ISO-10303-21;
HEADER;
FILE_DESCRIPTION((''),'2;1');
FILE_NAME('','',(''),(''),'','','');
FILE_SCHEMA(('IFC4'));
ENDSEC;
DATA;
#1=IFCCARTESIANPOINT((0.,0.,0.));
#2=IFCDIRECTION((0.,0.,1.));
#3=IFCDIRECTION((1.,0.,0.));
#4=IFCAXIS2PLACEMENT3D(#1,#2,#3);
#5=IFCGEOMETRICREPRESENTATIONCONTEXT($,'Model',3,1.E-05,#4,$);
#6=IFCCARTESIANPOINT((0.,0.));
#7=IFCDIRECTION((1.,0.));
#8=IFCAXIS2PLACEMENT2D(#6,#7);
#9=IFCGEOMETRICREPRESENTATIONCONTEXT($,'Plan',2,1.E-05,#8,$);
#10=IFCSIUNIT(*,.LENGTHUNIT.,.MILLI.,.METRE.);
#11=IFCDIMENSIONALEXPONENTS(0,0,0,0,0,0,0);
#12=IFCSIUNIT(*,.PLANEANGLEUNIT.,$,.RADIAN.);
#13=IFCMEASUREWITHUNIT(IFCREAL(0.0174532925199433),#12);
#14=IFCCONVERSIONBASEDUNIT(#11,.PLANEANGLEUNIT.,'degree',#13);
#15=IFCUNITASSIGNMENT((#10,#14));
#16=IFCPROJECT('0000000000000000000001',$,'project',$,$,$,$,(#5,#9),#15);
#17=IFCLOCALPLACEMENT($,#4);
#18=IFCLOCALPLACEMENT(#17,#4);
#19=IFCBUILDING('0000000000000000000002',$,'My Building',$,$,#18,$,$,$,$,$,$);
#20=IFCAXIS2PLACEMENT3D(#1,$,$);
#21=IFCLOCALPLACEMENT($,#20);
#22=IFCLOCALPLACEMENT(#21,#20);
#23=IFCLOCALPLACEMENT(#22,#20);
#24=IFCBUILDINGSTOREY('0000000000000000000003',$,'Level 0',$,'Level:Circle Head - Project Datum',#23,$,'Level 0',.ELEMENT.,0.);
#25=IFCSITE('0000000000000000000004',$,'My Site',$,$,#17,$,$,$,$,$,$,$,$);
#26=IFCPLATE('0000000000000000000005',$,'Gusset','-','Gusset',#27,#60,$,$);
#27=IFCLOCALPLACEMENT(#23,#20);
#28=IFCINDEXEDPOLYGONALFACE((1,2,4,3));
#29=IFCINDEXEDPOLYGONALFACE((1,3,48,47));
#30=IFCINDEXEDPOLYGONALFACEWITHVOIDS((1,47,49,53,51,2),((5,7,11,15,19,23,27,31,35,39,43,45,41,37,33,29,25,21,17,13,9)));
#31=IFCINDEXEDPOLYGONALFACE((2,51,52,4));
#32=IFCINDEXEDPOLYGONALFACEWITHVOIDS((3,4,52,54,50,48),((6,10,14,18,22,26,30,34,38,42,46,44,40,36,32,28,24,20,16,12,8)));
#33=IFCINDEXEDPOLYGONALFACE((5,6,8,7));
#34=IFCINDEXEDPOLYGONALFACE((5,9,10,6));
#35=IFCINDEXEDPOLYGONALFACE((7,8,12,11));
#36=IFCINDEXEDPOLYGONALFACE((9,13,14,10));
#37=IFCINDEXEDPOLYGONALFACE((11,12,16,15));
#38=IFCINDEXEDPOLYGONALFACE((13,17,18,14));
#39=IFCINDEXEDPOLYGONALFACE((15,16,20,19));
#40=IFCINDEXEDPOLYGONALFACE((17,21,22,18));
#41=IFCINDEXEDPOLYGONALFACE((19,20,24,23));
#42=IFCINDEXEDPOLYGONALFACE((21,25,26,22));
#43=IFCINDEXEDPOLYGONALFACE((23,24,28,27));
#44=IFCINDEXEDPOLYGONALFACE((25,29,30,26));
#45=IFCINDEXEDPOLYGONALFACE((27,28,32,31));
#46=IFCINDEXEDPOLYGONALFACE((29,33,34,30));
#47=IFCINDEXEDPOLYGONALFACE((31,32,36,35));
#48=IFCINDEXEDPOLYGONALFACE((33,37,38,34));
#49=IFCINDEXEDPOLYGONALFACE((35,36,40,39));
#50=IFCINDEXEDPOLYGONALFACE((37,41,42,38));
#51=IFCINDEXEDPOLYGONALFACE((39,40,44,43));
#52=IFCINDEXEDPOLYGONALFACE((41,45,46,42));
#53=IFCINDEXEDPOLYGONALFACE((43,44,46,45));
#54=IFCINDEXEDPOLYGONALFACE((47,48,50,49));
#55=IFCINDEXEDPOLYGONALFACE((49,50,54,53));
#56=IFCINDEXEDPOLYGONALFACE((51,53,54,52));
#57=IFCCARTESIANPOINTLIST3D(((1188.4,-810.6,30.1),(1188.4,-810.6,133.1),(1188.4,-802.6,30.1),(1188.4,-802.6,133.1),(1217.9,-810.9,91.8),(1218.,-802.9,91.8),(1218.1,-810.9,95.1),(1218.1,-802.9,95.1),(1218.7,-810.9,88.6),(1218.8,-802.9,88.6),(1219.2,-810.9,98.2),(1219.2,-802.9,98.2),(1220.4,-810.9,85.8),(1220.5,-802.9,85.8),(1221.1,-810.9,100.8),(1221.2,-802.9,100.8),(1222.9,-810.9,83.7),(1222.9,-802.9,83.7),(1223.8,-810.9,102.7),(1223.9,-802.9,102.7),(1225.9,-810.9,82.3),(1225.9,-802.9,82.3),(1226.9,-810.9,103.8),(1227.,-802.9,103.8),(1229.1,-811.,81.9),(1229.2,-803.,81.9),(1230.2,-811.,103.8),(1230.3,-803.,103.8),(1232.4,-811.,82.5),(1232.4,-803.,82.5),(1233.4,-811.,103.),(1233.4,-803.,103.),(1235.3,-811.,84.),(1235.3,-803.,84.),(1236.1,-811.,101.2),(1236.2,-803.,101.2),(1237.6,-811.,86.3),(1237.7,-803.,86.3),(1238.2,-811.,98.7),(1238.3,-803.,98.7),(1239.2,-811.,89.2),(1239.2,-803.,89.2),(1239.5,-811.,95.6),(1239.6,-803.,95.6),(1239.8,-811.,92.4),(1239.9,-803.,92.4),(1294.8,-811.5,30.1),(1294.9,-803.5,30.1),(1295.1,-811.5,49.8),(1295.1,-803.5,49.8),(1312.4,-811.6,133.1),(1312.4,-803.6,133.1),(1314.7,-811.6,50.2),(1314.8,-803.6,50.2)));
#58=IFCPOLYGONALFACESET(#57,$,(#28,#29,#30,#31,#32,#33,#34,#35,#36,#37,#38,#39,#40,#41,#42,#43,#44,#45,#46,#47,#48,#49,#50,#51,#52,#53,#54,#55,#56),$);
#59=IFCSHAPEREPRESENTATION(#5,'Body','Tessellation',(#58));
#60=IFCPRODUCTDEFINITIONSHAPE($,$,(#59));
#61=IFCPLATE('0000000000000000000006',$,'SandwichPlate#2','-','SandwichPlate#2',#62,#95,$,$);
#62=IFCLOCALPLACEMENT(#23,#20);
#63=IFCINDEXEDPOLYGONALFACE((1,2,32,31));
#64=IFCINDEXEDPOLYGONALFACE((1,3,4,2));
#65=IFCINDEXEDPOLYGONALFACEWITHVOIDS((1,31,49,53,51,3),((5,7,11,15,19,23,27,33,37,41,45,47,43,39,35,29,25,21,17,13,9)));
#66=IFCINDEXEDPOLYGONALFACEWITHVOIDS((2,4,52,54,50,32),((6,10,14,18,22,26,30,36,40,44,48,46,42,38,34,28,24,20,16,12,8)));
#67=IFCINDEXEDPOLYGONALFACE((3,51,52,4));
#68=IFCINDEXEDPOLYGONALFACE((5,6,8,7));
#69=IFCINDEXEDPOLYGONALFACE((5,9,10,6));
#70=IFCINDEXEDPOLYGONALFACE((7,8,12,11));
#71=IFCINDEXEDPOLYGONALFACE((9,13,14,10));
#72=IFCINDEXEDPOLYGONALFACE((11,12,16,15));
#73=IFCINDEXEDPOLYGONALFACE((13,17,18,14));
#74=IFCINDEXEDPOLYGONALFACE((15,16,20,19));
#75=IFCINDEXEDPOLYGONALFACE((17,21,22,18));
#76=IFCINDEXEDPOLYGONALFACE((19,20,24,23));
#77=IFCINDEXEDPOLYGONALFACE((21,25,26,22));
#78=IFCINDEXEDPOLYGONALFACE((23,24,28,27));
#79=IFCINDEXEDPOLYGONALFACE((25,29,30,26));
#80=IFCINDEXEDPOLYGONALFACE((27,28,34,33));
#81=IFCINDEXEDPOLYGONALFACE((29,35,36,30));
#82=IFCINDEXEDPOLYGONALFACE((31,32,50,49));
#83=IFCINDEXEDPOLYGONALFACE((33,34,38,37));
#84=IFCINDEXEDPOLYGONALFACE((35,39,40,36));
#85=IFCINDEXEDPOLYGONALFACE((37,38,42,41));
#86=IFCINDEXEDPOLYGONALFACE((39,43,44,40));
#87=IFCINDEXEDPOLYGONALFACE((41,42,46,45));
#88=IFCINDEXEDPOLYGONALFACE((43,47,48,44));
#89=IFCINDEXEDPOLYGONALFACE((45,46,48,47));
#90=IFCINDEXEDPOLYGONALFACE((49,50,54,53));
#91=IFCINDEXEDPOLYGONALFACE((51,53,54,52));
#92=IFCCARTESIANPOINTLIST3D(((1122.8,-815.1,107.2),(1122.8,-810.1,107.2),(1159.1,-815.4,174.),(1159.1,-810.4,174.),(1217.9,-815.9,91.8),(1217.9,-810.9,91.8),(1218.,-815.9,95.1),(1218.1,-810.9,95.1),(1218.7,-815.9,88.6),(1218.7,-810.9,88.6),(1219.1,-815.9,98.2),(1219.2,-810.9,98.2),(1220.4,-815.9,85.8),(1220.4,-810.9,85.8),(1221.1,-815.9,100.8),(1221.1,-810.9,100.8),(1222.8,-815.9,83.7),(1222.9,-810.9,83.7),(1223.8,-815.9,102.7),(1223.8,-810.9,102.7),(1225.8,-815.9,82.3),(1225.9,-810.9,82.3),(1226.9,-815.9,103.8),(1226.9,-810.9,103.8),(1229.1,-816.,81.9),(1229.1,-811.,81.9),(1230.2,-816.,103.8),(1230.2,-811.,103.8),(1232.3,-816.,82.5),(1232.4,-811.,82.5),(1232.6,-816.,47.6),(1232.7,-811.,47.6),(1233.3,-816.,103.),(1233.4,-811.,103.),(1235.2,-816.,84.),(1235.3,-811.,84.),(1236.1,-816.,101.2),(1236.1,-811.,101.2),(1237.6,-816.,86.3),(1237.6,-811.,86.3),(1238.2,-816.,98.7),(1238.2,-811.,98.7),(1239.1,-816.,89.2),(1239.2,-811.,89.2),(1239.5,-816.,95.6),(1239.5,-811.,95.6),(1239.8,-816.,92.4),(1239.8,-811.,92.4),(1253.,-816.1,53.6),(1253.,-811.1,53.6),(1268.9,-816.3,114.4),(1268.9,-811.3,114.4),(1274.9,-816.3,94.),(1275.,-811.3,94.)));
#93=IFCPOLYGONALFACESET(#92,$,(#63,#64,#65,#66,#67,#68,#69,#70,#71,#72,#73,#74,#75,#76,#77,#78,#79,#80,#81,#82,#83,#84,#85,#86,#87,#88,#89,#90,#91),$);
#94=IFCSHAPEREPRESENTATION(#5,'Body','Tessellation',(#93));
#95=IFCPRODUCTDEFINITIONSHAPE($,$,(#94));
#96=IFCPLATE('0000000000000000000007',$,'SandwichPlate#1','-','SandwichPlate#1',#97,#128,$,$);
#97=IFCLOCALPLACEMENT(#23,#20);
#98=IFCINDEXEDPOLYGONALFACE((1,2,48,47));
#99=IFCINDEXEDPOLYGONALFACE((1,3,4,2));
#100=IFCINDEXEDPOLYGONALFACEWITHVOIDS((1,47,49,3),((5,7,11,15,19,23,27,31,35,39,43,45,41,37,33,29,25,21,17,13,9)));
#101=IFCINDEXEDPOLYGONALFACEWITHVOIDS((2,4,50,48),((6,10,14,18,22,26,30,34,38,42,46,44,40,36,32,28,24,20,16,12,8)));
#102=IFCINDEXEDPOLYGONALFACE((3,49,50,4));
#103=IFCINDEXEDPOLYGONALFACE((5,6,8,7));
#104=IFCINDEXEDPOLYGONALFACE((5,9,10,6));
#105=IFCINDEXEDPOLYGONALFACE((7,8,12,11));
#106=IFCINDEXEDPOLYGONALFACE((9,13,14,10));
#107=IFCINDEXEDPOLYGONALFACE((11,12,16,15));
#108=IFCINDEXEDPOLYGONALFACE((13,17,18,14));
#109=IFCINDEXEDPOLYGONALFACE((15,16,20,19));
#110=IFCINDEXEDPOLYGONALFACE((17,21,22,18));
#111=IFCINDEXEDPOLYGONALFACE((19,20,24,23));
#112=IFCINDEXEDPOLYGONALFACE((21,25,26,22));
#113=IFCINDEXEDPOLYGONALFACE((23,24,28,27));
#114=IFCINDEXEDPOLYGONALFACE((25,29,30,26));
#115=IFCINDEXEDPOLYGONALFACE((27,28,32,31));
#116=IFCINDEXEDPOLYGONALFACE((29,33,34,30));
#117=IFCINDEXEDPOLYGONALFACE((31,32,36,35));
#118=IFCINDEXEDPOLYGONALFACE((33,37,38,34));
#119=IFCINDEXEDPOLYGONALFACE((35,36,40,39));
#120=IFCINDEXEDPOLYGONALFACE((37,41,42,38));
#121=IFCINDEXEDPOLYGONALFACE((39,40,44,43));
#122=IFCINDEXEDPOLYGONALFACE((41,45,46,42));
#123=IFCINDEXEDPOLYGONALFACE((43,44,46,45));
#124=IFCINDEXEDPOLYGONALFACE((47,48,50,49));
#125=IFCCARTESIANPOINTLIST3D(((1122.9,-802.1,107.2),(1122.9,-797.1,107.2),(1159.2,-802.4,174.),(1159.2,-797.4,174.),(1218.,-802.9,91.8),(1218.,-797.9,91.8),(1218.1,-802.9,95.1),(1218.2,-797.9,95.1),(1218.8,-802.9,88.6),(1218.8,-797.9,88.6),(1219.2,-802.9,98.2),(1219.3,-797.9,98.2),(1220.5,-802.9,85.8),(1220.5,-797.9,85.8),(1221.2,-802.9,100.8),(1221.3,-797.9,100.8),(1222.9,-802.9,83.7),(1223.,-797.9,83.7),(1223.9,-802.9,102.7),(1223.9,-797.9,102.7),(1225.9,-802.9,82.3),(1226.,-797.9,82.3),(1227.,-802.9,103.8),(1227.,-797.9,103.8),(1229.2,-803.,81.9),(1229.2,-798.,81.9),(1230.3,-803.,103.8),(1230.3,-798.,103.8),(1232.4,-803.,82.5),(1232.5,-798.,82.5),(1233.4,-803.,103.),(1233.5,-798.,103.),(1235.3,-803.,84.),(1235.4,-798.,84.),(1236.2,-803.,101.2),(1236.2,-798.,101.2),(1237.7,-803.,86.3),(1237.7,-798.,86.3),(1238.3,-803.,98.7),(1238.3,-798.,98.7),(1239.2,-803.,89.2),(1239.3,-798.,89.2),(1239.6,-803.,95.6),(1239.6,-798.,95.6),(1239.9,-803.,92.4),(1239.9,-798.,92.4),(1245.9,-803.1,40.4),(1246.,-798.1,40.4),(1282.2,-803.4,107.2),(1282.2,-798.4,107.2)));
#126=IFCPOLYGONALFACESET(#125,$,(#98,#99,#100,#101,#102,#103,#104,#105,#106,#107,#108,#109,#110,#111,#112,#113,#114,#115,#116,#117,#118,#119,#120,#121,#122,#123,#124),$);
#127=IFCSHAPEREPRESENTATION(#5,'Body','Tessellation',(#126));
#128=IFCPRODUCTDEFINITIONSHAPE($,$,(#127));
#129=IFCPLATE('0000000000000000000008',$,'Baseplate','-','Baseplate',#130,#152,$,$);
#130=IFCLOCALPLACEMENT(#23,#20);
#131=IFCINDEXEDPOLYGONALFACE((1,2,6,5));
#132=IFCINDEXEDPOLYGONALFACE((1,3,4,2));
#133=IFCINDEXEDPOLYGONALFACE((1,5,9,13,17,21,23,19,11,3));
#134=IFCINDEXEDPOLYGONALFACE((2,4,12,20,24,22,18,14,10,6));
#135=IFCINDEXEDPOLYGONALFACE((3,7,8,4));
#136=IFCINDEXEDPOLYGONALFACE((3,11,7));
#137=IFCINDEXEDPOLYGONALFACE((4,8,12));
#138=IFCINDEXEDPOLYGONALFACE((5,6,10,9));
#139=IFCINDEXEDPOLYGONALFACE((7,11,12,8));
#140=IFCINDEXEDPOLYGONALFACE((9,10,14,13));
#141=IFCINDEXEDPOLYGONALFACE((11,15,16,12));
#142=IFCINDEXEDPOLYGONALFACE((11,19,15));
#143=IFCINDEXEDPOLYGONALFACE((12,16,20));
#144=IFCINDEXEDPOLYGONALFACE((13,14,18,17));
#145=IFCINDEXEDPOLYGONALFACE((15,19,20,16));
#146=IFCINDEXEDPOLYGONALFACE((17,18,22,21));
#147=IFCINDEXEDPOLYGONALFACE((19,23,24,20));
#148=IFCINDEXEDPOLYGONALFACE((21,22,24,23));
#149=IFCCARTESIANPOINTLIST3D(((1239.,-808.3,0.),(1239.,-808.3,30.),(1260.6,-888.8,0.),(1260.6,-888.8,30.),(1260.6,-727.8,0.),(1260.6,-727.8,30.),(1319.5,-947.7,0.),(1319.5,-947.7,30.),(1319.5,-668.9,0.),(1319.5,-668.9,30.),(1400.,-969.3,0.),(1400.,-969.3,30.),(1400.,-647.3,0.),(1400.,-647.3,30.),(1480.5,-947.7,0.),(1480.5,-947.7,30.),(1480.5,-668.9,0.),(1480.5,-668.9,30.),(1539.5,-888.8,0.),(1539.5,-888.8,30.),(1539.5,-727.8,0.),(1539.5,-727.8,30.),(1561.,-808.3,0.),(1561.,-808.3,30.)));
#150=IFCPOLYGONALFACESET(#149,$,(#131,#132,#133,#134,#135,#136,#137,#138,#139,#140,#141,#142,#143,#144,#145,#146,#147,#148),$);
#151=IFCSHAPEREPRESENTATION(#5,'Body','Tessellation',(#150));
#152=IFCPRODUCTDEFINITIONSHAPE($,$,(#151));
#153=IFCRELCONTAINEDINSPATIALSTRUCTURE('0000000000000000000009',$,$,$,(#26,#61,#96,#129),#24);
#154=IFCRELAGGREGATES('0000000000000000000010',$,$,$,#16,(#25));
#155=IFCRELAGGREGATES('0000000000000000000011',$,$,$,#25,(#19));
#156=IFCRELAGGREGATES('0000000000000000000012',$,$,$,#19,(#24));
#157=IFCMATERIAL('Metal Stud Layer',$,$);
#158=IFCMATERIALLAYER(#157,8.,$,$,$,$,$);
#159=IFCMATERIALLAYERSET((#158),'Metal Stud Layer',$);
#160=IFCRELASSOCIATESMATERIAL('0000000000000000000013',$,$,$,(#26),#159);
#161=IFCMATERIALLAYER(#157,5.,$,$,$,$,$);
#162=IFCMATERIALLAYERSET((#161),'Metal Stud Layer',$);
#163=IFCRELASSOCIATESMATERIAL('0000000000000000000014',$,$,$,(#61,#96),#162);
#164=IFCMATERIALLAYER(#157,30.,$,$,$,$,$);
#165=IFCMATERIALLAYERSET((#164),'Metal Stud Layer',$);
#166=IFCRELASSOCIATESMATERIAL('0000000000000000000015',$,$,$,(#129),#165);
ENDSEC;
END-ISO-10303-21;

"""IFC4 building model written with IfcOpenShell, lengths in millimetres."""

from ifc_helpers import new_model, entity, si_unit, converted_unit, point, frame, frame_2d, origin, origin_with_axes, origin_2d_with_axis, place, context, project, spatial, polyline, circle_curve, line_curve, trimmed, segment, composite_curve, circle, outline, extrude, material, layer, layer_set, element, save


model = new_model("IFC4")

# Units and contexts
model_context = context("Model", 3, precision=1e-05, world=origin_with_axes())
plan_context = context("Plan", 2, precision=1e-05, world=origin_2d_with_axis())
ifc_project = project(units=[si_unit("LENGTHUNIT", "METRE", prefix="MILLI"), converted_unit("PLANEANGLEUNIT", "degree", entity("IfcReal", 0.0174532925199433), si_unit("PLANEANGLEUNIT", "RADIAN"), dimensions=[0, 0, 0, 0, 0, 0, 0])], contexts=[model_context, plan_context])

# Site, building, storey
site_placement = place(None, origin_with_axes())
site = spatial("IfcSite", under=ifc_project, at=site_placement, Name="My Site")
building_placement = place(site_placement, origin_with_axes())
building = spatial("IfcBuilding", under=site, at=building_placement, Name="My Building")
placement_1 = place(None, origin())
placement_2 = place(placement_1, origin())
storey_placement = place(placement_2, origin())
storey = spatial("IfcBuildingStorey", under=building, at=storey_placement, Name="Level 0", ObjectType="Level:Circle Head - Project Datum", LongName="Level 0", CompositionType="ELEMENT", Elevation=0.0)

# Shared definitions
ifc_material_1 = material(Name="Metal Stud Layer")
ifc_layer_1 = layer(ifc_material_1, 5.0)
ifc_layer_set_1 = layer_set([ifc_layer_1], Name="Metal Stud Layer")

# Plate, openings
ifc_layer_2 = layer(ifc_material_1, 8.0)
ifc_layer_set_2 = layer_set([ifc_layer_2], Name="Metal Stud Layer")
plate_1_placement = place(storey_placement, frame((1309.2, -803.6, 143.6), z_axis=(-0.007837, -0.999969, 0.0), x_axis=(-0.999419, 0.007833, -0.033166)))
plate_1 = element("IfcPlate", 1, at=plate_1_placement, inside=storey, material=ifc_layer_set_2, Name="Gusset", Description="-", ObjectType="Gusset", context=model_context, shape_type="SweptSolid", body=[
    extrude(outline(polyline([(-2.5, 93.5), (-2.9, 10.5), (121.1, 6.4), (124.5, 109.4), (18.1, 112.9), (17.2, 93.2), (-2.5, 93.5)])), origin_with_axes(), (0.0, 0.0, 1.0), 8.0),
])
opening_1_placement = place(plate_1_placement, origin_with_axes())
element("IfcOpeningElement", 2, at=opening_1_placement, cuts=plate_1, ObjectType="Opening", context=model_context, shape_type="SweptSolid", body=[
    extrude(outline(composite_curve([segment(trimmed(line_curve((17.2, 93.2), (-0.999857, 0.016904), 19.685532), [point((17.2, 93.2))], [point((-2.5, 93.5))], True, "CARTESIAN"), True, "CONTINUOUS"), segment(trimmed(circle_curve(frame_2d((-2.2, 113.8), x_axis=(1.0, 0.0)), 20.3), [point((-2.5, 93.5))], [point((18.1, 112.9))], True, "CARTESIAN"), True, "CONTINUOUS"), segment(trimmed(line_curve((18.1, 112.9), (-0.046684, -0.99891), 19.685532), [point((18.1, 112.9))], [point((17.2, 93.2))], True, "CARTESIAN"), True, "CONTINUOUS")], self_intersect=False)), origin(), (0.0, 0.0, 1.0), 8.0),
])
opening_2_placement = place(plate_1_placement, frame((81.9, 48.0, 8.5), z_axis=(0.0, 0.0, -1.0), x_axis=(0.862503, -0.506052, 0.0)))
element("IfcOpeningElement", 3, at=opening_2_placement, cuts=plate_1, ObjectType="Opening", context=model_context, shape_type="SweptSolid", body=[
    extrude(circle(Radius=11.0, at=origin_2d_with_axis()), origin(), (0.0, 0.0, 1.0), 9.0),
])

# Plates, openings
plate_2_placement = place(storey_placement, frame((1282.1, -816.4, 107.2), z_axis=(0.007837, 0.999969, 0.0), x_axis=(-0.477154, 0.00374, -0.878812)))
plate_2 = element("IfcPlate", 4, at=plate_2_placement, inside=storey, material=ifc_layer_set_1, Name="SandwichPlate#2", Description="-", ObjectType="SandwichPlate#2", context=model_context, shape_type="SweptSolid", body=[
    extrude(outline(polyline([(15.0, 0.0), (61.0, 0.0), (76.0, 15.0), (76.0, 140.0), (0.0, 140.0), (0.0, 15.0), (15.0, 0.0)])), origin_with_axes(), (0.0, 0.0, 1.0), 5.0),
])
opening_3_placement = place(plate_2_placement, frame((38.0, 40.0, -0.5), z_axis=(0.0, 0.0, 1.0), x_axis=(0.0, 1.0, 0.0)))
element("IfcOpeningElement", 5, at=opening_3_placement, cuts=plate_2, ObjectType="Opening", context=model_context, shape_type="SweptSolid", body=[
    extrude(circle(Radius=11.0, at=origin_2d_with_axis()), origin(), (0.0, 0.0, 1.0), 6.0),
])
plate_3_placement = place(storey_placement, frame((1282.2, -803.4, 107.2), z_axis=(0.007837, 0.999969, 0.0), x_axis=(-0.477154, 0.00374, -0.878812)))
plate_3 = element("IfcPlate", 6, at=plate_3_placement, inside=storey, material=ifc_layer_set_1, Name="SandwichPlate#1", Description="-", ObjectType="SandwichPlate#1", context=model_context, shape_type="SweptSolid", body=[
    extrude(outline(polyline([(0.0, 0.0), (76.0, 0.0), (76.0, 140.0), (0.0, 140.0), (0.0, 0.0)])), origin_with_axes(), (0.0, 0.0, 1.0), 5.0),
])
opening_4_placement = place(plate_3_placement, frame((38.0, 40.0, -0.5), z_axis=(0.0, 0.0, 1.0), x_axis=(0.0, 1.0, 0.0)))
element("IfcOpeningElement", 7, at=opening_4_placement, cuts=plate_3, ObjectType="Opening", context=model_context, shape_type="SweptSolid", body=[
    extrude(circle(Radius=11.0, at=origin_2d_with_axis()), origin(), (0.0, 0.0, 1.0), 6.0),
])

# Plate, openings
ifc_layer_3 = layer(ifc_material_1, 30.0)
ifc_layer_set_3 = layer_set([ifc_layer_3], Name="Metal Stud Layer")
plate_4_placement = place(storey_placement, frame((1480.5, -668.9, 30.0), z_axis=(0.0, 0.0, -1.0), x_axis=(0.866025, -0.5, 0.0)))
plate_4 = element("IfcPlate", 8, at=plate_4_placement, inside=storey, material=ifc_layer_set_3, Name="Baseplate", Description="-", ObjectType="Baseplate", context=model_context, shape_type="SweptSolid", body=[
    extrude(outline(polyline([(161.0, 0.0), (161.0, 322.0), (-161.0, 322.0), (-161.0, 0.0), (161.0, 0.0)])), origin_with_axes(), (0.0, 0.0, 1.0), 30.0),
])
opening_5_placement = place(plate_4_placement, frame((0.0, 0.0, 0.0), z_axis=(0.0, 0.0, 1.0), x_axis=(1.0, 0.0, 0.0)))
element("IfcOpeningElement", 9, at=opening_5_placement, cuts=plate_4, ObjectType="Opening", context=model_context, shape_type="SweptSolid", body=[
    extrude(outline(composite_curve([segment(trimmed(line_curve((-161.0, 0.0), (1.0, 0.0), 161.0), [point((-161.0, 0.0))], [point((0.0, 0.0))], True, "CARTESIAN"), True, "CONTINUOUS"), segment(trimmed(circle_curve(frame_2d((0.0, 161.0), x_axis=(-1.0, 0.0)), 161.0), [point((0.0, 0.0))], [point((-161.0, 161.0))], False, "CARTESIAN"), True, "CONTINUOUS"), segment(trimmed(line_curve((-161.0, 161.0), (0.0, -1.0), 161.0), [point((-161.0, 161.0))], [point((-161.0, 0.0))], True, "CARTESIAN"), True, "CONTINUOUS")], self_intersect=False)), origin(), (0.0, 0.0, 1.0), 30.0),
])
opening_6_placement = place(plate_4_placement, frame((0.0, 0.0, 0.0), z_axis=(0.0, 0.0, 1.0), x_axis=(1.0, 0.0, 0.0)))
element("IfcOpeningElement", 10, at=opening_6_placement, cuts=plate_4, ObjectType="Opening", context=model_context, shape_type="SweptSolid", body=[
    extrude(outline(composite_curve([segment(trimmed(line_curve((-161.0, 322.0), (0.0, -1.0), 161.0), [point((-161.0, 322.0))], [point((-161.0, 161.0))], True, "CARTESIAN"), True, "CONTINUOUS"), segment(trimmed(circle_curve(frame_2d((0.0, 161.0), x_axis=(-1.0, 0.0)), 161.0), [point((-161.0, 161.0))], [point((0.0, 322.0))], False, "CARTESIAN"), True, "CONTINUOUS"), segment(trimmed(line_curve((0.0, 322.0), (-1.0, 0.0), 161.0), [point((0.0, 322.0))], [point((-161.0, 322.0))], True, "CARTESIAN"), True, "CONTINUOUS")], self_intersect=False)), origin(), (0.0, 0.0, 1.0), 30.0),
])
opening_7_placement = place(plate_4_placement, frame((0.0, 0.0, 0.0), z_axis=(0.0, 0.0, 1.0), x_axis=(1.0, 0.0, 0.0)))
element("IfcOpeningElement", 11, at=opening_7_placement, cuts=plate_4, ObjectType="Opening", context=model_context, shape_type="SweptSolid", body=[
    extrude(outline(composite_curve([segment(trimmed(line_curve((161.0, 0.0), (0.0, 1.0), 161.0), [point((161.0, 0.0))], [point((161.0, 161.0))], True, "CARTESIAN"), True, "CONTINUOUS"), segment(trimmed(circle_curve(frame_2d((0.0, 161.0), x_axis=(-1.0, 0.0)), 161.0), [point((161.0, 161.0))], [point((0.0, 0.0))], False, "CARTESIAN"), True, "CONTINUOUS"), segment(trimmed(line_curve((0.0, 0.0), (1.0, 0.0), 161.0), [point((0.0, 0.0))], [point((161.0, 0.0))], True, "CARTESIAN"), True, "CONTINUOUS")], self_intersect=False)), origin(), (0.0, 0.0, 1.0), 30.0),
])
opening_8_placement = place(plate_4_placement, frame((0.0, 0.0, 0.0), z_axis=(0.0, 0.0, 1.0), x_axis=(1.0, 0.0, 0.0)))
element("IfcOpeningElement", 12, at=opening_8_placement, cuts=plate_4, ObjectType="Opening", context=model_context, shape_type="SweptSolid", body=[
    extrude(outline(composite_curve([segment(trimmed(line_curve((161.0, 322.0), (-1.0, 0.0), 161.0), [point((161.0, 322.0))], [point((0.0, 322.0))], True, "CARTESIAN"), True, "CONTINUOUS"), segment(trimmed(circle_curve(frame_2d((0.0, 161.0), x_axis=(-1.0, 0.0)), 161.0), [point((0.0, 322.0))], [point((161.0, 161.0))], False, "CARTESIAN"), True, "CONTINUOUS"), segment(trimmed(line_curve((161.0, 161.0), (0.0, 1.0), 161.0), [point((161.0, 161.0))], [point((161.0, 322.0))], True, "CARTESIAN"), True, "CONTINUOUS")], self_intersect=False)), origin(), (0.0, 0.0, 1.0), 30.0),
])

save(model, "model.ifc")
